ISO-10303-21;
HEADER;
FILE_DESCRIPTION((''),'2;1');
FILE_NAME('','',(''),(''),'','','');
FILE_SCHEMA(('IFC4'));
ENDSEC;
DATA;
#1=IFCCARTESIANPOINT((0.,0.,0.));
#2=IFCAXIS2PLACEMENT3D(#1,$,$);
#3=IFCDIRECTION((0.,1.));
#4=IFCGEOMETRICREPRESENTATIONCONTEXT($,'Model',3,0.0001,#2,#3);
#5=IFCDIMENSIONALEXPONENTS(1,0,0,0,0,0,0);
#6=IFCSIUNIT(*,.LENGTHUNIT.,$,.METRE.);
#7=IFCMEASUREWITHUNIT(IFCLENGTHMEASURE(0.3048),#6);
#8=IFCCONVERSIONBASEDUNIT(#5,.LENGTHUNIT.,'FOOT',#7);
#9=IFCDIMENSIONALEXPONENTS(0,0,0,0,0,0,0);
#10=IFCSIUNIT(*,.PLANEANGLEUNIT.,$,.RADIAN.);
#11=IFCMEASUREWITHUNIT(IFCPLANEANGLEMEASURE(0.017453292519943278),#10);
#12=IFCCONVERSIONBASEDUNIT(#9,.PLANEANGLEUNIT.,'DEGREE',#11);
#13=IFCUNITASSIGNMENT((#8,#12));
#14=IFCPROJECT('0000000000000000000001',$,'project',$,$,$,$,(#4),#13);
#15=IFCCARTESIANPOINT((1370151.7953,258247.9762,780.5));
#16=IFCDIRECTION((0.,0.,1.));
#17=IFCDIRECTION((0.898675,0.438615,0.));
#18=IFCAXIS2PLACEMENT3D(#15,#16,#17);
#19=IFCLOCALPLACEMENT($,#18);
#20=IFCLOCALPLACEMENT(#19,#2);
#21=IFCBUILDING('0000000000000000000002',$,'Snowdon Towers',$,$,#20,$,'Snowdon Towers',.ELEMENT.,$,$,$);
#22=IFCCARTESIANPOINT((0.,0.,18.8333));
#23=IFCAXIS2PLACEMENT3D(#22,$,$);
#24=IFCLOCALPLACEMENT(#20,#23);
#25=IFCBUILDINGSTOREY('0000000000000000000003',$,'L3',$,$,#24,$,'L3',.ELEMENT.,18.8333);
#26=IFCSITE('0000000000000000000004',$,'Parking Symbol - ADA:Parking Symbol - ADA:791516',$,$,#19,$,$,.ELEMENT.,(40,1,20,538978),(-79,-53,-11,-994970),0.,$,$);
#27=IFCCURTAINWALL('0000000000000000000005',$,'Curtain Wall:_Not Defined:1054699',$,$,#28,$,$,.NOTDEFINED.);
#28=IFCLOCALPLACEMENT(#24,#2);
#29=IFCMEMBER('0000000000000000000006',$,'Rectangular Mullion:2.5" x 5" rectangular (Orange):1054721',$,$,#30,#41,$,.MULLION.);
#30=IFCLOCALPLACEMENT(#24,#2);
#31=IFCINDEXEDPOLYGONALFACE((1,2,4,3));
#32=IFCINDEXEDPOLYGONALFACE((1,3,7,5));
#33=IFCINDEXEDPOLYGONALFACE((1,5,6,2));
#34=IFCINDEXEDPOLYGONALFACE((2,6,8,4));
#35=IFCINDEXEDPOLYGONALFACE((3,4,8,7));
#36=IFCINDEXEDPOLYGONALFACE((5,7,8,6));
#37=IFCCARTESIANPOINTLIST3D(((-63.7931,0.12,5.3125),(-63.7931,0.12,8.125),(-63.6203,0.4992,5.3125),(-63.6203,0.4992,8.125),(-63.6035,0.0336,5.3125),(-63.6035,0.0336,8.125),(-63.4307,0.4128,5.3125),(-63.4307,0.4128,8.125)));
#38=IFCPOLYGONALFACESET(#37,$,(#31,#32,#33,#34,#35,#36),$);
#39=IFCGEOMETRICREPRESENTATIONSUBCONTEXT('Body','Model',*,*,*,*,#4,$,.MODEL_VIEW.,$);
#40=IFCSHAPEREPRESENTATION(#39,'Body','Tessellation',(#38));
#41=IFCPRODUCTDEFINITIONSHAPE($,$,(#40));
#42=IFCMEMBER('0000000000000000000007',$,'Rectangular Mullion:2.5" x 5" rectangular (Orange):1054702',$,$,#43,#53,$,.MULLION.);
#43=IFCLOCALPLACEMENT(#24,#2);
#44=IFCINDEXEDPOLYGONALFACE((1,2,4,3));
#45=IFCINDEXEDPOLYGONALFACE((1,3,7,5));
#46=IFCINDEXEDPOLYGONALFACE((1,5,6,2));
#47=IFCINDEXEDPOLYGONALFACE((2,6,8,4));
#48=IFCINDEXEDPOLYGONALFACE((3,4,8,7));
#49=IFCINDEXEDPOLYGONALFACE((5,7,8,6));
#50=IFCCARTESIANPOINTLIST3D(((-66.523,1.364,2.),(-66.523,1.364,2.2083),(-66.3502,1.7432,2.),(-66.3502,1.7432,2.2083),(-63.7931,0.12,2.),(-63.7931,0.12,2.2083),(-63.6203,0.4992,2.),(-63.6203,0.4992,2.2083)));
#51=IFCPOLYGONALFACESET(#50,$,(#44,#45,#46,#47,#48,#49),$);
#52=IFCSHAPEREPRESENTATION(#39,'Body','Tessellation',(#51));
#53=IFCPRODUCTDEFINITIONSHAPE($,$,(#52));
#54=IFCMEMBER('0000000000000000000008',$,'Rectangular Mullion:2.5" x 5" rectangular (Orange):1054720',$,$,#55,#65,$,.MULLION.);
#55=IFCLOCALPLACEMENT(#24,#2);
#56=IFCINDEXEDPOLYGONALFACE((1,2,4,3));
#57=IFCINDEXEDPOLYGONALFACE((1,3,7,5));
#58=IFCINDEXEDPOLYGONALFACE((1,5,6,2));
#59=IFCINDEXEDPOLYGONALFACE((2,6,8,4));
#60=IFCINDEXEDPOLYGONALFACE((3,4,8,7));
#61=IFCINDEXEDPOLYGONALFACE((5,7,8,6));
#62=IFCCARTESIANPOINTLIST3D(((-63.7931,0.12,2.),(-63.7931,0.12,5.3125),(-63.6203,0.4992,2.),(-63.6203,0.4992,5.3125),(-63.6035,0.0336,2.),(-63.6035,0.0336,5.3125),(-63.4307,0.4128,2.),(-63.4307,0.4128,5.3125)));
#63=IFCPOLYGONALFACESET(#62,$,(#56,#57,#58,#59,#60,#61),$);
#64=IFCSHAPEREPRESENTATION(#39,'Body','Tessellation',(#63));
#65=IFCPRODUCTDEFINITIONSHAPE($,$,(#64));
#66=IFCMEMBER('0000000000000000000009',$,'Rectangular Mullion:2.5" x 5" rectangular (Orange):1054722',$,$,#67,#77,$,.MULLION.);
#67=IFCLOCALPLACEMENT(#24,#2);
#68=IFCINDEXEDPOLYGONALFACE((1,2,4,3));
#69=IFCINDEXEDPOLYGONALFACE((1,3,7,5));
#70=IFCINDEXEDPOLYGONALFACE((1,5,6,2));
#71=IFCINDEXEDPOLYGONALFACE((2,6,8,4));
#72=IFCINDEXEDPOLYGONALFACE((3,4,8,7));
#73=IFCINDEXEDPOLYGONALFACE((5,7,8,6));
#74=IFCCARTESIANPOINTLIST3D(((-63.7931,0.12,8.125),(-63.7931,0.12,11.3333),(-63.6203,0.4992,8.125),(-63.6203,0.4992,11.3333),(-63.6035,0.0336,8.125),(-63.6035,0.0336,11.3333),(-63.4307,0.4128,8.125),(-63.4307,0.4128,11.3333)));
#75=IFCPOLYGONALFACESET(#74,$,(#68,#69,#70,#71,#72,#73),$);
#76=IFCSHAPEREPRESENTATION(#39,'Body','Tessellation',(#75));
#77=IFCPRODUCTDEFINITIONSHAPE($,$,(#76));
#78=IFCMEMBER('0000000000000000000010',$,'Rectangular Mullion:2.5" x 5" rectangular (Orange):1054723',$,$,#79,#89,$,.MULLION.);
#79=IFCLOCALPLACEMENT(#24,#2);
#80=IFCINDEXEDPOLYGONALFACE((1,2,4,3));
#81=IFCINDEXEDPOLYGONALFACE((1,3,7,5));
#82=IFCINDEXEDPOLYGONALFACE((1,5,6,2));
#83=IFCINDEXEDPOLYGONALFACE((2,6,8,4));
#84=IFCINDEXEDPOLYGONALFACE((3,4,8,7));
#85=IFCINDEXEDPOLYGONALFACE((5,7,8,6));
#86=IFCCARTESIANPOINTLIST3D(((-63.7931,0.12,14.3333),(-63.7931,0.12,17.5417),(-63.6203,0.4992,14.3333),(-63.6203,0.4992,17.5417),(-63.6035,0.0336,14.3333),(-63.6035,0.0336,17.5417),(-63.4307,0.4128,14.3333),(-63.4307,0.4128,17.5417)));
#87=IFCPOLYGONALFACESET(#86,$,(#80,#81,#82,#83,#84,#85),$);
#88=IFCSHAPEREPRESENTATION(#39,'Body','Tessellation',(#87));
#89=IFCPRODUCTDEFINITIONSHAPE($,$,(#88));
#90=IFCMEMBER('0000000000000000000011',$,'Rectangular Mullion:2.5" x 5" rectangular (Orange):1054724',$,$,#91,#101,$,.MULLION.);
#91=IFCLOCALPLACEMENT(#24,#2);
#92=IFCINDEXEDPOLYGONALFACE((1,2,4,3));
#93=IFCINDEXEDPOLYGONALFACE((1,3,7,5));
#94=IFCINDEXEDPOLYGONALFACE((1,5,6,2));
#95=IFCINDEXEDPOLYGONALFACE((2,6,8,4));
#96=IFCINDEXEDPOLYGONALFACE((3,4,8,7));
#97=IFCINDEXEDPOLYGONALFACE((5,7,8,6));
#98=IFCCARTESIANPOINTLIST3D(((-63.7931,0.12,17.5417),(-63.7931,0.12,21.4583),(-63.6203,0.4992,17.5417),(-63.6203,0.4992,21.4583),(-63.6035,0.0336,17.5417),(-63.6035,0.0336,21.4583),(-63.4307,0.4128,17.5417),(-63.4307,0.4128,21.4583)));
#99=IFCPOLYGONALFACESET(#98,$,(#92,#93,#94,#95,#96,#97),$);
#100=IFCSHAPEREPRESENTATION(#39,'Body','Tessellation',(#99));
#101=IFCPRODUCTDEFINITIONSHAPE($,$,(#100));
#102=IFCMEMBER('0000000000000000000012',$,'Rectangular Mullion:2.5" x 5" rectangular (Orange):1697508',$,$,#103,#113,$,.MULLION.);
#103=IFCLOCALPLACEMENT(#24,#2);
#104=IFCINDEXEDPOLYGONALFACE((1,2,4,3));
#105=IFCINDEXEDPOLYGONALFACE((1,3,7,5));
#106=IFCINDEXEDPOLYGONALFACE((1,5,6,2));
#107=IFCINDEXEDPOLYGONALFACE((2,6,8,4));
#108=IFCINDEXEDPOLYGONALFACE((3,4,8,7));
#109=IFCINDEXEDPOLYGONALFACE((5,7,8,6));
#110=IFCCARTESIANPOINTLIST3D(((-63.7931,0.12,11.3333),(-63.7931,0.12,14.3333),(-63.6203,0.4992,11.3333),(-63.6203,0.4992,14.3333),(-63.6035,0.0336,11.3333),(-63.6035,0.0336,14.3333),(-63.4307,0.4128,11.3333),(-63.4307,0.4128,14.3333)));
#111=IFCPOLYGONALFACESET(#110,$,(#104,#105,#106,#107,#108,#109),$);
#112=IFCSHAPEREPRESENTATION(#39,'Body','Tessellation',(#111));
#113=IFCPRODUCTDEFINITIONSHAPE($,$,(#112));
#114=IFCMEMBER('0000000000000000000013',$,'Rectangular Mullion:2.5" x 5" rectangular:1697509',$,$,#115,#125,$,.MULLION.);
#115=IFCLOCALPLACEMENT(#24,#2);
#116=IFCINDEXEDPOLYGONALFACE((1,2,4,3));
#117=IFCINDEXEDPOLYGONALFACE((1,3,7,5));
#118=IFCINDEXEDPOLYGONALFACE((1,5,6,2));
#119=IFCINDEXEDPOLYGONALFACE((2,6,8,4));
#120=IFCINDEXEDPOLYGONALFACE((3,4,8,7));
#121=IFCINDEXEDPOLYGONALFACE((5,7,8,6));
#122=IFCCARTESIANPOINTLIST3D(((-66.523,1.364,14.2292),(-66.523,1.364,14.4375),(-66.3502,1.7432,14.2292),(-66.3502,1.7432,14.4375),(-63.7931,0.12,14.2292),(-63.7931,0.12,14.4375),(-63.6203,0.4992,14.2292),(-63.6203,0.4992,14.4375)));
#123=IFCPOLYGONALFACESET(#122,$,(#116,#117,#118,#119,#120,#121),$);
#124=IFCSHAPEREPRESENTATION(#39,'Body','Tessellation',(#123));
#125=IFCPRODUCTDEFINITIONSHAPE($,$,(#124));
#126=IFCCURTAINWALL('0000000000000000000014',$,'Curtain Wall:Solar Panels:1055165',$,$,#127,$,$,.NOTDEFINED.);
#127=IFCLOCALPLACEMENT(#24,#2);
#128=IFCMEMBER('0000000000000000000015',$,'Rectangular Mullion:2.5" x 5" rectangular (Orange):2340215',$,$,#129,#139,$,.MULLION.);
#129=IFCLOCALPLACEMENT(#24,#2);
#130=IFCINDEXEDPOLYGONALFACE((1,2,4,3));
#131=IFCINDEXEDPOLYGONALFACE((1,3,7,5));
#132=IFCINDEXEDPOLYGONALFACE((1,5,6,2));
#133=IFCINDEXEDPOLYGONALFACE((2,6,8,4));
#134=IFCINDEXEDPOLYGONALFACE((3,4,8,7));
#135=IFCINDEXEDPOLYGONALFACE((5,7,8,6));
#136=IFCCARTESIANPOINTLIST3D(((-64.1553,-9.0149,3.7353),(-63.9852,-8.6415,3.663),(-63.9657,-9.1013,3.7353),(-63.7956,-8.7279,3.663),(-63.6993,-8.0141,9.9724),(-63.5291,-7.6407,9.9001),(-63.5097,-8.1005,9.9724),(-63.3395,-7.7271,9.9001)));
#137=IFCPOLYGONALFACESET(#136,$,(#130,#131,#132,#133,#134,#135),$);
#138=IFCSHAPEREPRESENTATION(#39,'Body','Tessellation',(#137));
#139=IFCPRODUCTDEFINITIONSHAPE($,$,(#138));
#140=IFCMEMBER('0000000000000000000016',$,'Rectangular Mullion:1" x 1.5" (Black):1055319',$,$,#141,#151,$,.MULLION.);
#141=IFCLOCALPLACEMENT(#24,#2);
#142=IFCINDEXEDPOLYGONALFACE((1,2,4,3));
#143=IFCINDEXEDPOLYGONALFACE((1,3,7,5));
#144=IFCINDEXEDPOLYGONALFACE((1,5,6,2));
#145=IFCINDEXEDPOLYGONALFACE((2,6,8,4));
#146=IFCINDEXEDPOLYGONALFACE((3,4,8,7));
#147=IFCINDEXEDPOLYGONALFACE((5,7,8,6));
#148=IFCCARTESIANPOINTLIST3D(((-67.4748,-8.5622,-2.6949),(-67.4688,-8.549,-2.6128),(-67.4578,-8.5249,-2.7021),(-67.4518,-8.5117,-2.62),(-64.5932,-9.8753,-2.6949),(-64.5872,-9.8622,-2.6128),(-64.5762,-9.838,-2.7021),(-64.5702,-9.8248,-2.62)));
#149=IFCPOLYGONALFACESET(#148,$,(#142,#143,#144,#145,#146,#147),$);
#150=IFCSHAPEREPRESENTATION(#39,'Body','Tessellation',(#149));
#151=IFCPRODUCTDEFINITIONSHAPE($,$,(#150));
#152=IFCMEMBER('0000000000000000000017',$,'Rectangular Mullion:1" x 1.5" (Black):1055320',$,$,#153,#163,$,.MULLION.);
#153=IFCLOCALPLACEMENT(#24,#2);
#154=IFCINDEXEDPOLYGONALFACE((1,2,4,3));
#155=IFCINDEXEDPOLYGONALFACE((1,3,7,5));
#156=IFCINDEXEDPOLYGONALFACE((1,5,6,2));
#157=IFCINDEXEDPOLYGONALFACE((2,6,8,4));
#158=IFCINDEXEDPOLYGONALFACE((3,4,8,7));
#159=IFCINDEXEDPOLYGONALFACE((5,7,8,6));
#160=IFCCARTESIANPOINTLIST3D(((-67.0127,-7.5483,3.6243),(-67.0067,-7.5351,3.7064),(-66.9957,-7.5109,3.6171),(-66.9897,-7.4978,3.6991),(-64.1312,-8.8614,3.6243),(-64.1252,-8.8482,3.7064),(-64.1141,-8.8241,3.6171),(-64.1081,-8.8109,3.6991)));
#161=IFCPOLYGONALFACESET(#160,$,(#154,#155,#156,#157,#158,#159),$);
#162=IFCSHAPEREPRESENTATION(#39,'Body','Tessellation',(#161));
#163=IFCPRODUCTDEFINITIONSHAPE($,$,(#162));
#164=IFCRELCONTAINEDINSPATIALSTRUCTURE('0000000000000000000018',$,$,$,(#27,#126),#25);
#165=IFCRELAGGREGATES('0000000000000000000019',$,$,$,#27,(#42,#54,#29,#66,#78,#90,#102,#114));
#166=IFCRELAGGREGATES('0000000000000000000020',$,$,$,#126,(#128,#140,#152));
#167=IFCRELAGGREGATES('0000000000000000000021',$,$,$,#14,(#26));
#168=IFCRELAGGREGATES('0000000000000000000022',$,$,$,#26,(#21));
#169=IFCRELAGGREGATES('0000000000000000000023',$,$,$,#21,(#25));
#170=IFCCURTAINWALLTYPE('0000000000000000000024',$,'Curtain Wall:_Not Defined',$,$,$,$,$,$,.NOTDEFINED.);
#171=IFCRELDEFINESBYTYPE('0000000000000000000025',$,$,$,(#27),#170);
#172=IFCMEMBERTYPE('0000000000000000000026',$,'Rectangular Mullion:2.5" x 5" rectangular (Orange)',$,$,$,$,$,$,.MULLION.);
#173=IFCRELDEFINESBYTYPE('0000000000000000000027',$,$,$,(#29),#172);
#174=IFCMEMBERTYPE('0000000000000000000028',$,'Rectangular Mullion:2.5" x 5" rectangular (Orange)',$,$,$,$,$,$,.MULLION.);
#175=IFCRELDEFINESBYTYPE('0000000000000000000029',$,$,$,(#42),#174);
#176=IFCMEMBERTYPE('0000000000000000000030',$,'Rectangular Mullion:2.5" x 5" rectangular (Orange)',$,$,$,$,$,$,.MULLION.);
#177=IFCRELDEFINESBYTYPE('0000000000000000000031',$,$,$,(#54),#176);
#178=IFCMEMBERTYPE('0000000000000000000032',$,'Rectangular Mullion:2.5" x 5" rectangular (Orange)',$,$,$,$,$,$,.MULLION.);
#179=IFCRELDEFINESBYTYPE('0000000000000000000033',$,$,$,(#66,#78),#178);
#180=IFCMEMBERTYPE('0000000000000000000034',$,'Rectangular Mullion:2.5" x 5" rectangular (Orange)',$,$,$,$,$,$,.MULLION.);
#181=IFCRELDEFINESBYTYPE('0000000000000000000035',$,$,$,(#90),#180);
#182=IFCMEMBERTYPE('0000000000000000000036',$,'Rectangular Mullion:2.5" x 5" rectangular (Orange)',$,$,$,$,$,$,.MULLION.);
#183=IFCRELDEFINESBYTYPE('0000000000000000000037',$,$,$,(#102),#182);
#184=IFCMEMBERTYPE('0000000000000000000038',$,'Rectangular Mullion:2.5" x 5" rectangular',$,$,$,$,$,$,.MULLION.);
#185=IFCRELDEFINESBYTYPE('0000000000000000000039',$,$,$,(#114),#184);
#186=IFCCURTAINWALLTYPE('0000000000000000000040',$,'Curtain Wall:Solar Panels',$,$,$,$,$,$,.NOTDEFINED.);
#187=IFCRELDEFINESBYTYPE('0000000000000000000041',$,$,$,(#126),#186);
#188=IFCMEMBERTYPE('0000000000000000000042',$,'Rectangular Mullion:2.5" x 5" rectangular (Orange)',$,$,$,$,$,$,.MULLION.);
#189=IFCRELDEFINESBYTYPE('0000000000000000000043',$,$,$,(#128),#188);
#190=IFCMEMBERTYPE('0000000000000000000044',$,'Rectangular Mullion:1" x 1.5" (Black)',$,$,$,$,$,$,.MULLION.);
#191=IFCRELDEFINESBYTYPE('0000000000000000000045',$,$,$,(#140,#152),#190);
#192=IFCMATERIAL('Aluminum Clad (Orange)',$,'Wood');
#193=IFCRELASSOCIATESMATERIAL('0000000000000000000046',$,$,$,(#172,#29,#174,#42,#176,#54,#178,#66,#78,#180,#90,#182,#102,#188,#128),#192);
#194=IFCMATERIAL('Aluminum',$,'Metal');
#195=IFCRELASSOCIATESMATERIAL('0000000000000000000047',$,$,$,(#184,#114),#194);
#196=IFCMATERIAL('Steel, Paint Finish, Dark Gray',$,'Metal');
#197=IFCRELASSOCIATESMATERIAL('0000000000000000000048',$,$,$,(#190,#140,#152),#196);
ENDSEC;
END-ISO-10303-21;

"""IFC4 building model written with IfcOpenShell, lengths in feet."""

from ifc_helpers import new_model, entity, si_unit, converted_unit, direction, frame, origin, place, context, subcontext, project, spatial, indexed_curve, outline, extrude, source, transform, mapped, material, type_object, type_shapes, element, aggregate, save


model = new_model("IFC4")

# Units and contexts
model_context = context("Model", 3, precision=0.0001, world=origin(), true_north=direction((0.0, 1.0)))
body_context = subcontext(model_context, "Body", "Model", "MODEL_VIEW")
ifc_project = project(units=[converted_unit("LENGTHUNIT", "FOOT", entity("IfcLengthMeasure", 0.3048), si_unit("LENGTHUNIT", "METRE"), dimensions=[1, 0, 0, 0, 0, 0, 0]), converted_unit("PLANEANGLEUNIT", "DEGREE", entity("IfcPlaneAngleMeasure", 0.017453292519943278), si_unit("PLANEANGLEUNIT", "RADIAN"), dimensions=[0, 0, 0, 0, 0, 0, 0])], contexts=[model_context])

# Site, building, storey
site_placement = place(None, frame((1370151.7953, 258247.9762, 780.5), z_axis=(0.0, 0.0, 1.0), x_axis=(0.898675, 0.438615, 0.0)))
site = spatial("IfcSite", under=ifc_project, at=site_placement, Name="Parking Symbol - ADA:Parking Symbol - ADA:791516", CompositionType="ELEMENT", RefLatitude=(40, 1, 20, 538978), RefLongitude=(-79, -53, -11, -994970), RefElevation=0.0)
building_placement = place(site_placement, origin())
building = spatial("IfcBuilding", under=site, at=building_placement, Name="Snowdon Towers", LongName="Snowdon Towers", CompositionType="ELEMENT")
storey_placement = place(building_placement, frame((0.0, 0.0, 18.8333)))
storey = spatial("IfcBuildingStorey", under=building, at=storey_placement, Name="L3", LongName="L3", CompositionType="ELEMENT", Elevation=18.8333)

# Curtain walls, members
curtain_wall_type_1 = type_object("IfcCurtainWallType", Name="Curtain Wall:_Not Defined", PredefinedType="NOTDEFINED")
curtain_wall_1_placement = place(storey_placement, frame((0.0, 0.0, -18.8333)))
curtain_wall_1 = element("IfcCurtainWall", 1, at=curtain_wall_1_placement, inside=storey, type_object=curtain_wall_type_1, Name="Curtain Wall:_Not Defined:1054699", PredefinedType="NOTDEFINED")
ifc_material_1 = material(Name="Aluminum Clad (Orange)", Category="Wood")
member_type_1 = type_object("IfcMemberType", Name="Rectangular Mullion:2.5\" x 5\" rectangular (Orange)", PredefinedType="MULLION", material=ifc_material_1)
shared_shape_1 = source(origin(), body_context, "Body", "SweptSolid", [
    extrude(outline(indexed_curve([(-0.1042, -0.2083), (0.1042, -0.2083), (0.1042, 0.2083), (-0.1042, 0.2083), (-0.1042, -0.2083)], self_intersect=False)), frame((-0.1042, 0.0, -2.8125), z_axis=(0.0, 0.0, 1.0), x_axis=(-1.0, 0.0, 0.0)), (0.0, 0.0, 1.0), 2.8125),
])
type_shapes(member_type_1, [shared_shape_1])
member_1_placement = place(curtain_wall_1_placement, frame((-63.5171, 0.2232, 26.9583), z_axis=(0.0, 0.0, 1.0), x_axis=(0.909972, -0.414671, 0.0)))
member_1 = element("IfcMember", 2, at=member_1_placement, type_object=member_type_1, material=ifc_material_1, Name="Rectangular Mullion:2.5\" x 5\" rectangular (Orange):1054721", PredefinedType="MULLION", context=body_context, shape_type="MappedRepresentation", body=[
    mapped(shared_shape_1, transform((0.0, 0.0, 0.0), scale=1.0)),
])
member_type_2 = type_object("IfcMemberType", Name="Rectangular Mullion:2.5\" x 5\" rectangular (Orange)", PredefinedType="MULLION", material=ifc_material_1)
shared_shape_2 = source(origin(), body_context, "Body", "SweptSolid", [
    extrude(outline(indexed_curve([(-0.1042, -0.2083), (0.1042, -0.2083), (0.1042, 0.2083), (-0.1042, 0.2083), (-0.1042, -0.2083)], self_intersect=False)), frame((-0.1042, 0.0, -3.0), z_axis=(0.0, 0.0, 1.0), x_axis=(-1.0, 0.0, 0.0)), (0.0, 0.0, 1.0), 3.0),
])
type_shapes(member_type_2, [shared_shape_2])
member_2_placement = place(curtain_wall_1_placement, frame((-63.7067, 0.3096, 20.8333), z_axis=(0.909972, -0.414671, 0.0), x_axis=(0.0, 0.0, -1.0)))
member_2 = element("IfcMember", 3, at=member_2_placement, type_object=member_type_2, material=ifc_material_1, Name="Rectangular Mullion:2.5\" x 5\" rectangular (Orange):1054702", PredefinedType="MULLION", context=body_context, shape_type="MappedRepresentation", body=[
    mapped(shared_shape_2, transform((0.0, 0.0, 0.0), scale=1.0)),
])
member_type_3 = type_object("IfcMemberType", Name="Rectangular Mullion:2.5\" x 5\" rectangular (Orange)", PredefinedType="MULLION", material=ifc_material_1)
shared_shape_3 = source(origin(), body_context, "Body", "SweptSolid", [
    extrude(outline(indexed_curve([(-0.1042, -0.2083), (0.1042, -0.2083), (0.1042, 0.2083), (-0.1042, 0.2083), (-0.1042, -0.2083)], self_intersect=False)), frame((-0.1042, 0.0, -3.3125), z_axis=(0.0, 0.0, 1.0), x_axis=(-1.0, 0.0, 0.0)), (0.0, 0.0, 1.0), 3.3125),
])
type_shapes(member_type_3, [shared_shape_3])
member_3_placement = place(curtain_wall_1_placement, frame((-63.5171, 0.2232, 24.1458), z_axis=(0.0, 0.0, 1.0), x_axis=(0.909972, -0.414671, 0.0)))
member_3 = element("IfcMember", 4, at=member_3_placement, type_object=member_type_3, material=ifc_material_1, Name="Rectangular Mullion:2.5\" x 5\" rectangular (Orange):1054720", PredefinedType="MULLION", context=body_context, shape_type="MappedRepresentation", body=[
    mapped(shared_shape_3, transform((0.0, 0.0, 0.0), scale=1.0)),
])
member_type_4 = type_object("IfcMemberType", Name="Rectangular Mullion:2.5\" x 5\" rectangular (Orange)", PredefinedType="MULLION", material=ifc_material_1)
shared_shape_4 = source(origin(), body_context, "Body", "SweptSolid", [
    extrude(outline(indexed_curve([(-0.1042, -0.2083), (0.1042, -0.2083), (0.1042, 0.2083), (-0.1042, 0.2083), (-0.1042, -0.2083)], self_intersect=False)), frame((-0.1042, 0.0, -3.2083), z_axis=(0.0, 0.0, 1.0), x_axis=(-1.0, 0.0, 0.0)), (0.0, 0.0, 1.0), 3.2083),
])
type_shapes(member_type_4, [shared_shape_4])
member_4_placement = place(curtain_wall_1_placement, frame((-63.5171, 0.2232, 30.1667), z_axis=(0.0, 0.0, 1.0), x_axis=(0.909972, -0.414671, 0.0)))
member_4 = element("IfcMember", 5, at=member_4_placement, type_object=member_type_4, material=ifc_material_1, Name="Rectangular Mullion:2.5\" x 5\" rectangular (Orange):1054722", PredefinedType="MULLION", context=body_context, shape_type="MappedRepresentation", body=[
    mapped(shared_shape_4, transform((0.0, 0.0, 0.0), scale=1.0)),
])
member_5_placement = place(curtain_wall_1_placement, frame((-63.5171, 0.2232, 36.375), z_axis=(0.0, 0.0, 1.0), x_axis=(0.909972, -0.414671, 0.0)))
member_5 = element("IfcMember", 6, at=member_5_placement, type_object=member_type_4, material=ifc_material_1, Name="Rectangular Mullion:2.5\" x 5\" rectangular (Orange):1054723", PredefinedType="MULLION", context=body_context, shape_type="MappedRepresentation", body=[
    mapped(shared_shape_4, transform((0.0, 0.0, 0.0), scale=1.0)),
])
member_type_5 = type_object("IfcMemberType", Name="Rectangular Mullion:2.5\" x 5\" rectangular (Orange)", PredefinedType="MULLION", material=ifc_material_1)
shared_shape_5 = source(origin(), body_context, "Body", "SweptSolid", [
    extrude(outline(indexed_curve([(-0.1042, -0.2083), (0.1042, -0.2083), (0.1042, 0.2083), (-0.1042, 0.2083), (-0.1042, -0.2083)], self_intersect=False)), frame((-0.1042, 0.0, -3.9167), z_axis=(0.0, 0.0, 1.0), x_axis=(-1.0, 0.0, 0.0)), (0.0, 0.0, 1.0), 3.9167),
])
type_shapes(member_type_5, [shared_shape_5])
member_6_placement = place(curtain_wall_1_placement, frame((-63.5171, 0.2232, 40.2917), z_axis=(0.0, 0.0, 1.0), x_axis=(0.909972, -0.414671, 0.0)))
member_6 = element("IfcMember", 7, at=member_6_placement, type_object=member_type_5, material=ifc_material_1, Name="Rectangular Mullion:2.5\" x 5\" rectangular (Orange):1054724", PredefinedType="MULLION", context=body_context, shape_type="MappedRepresentation", body=[
    mapped(shared_shape_5, transform((0.0, 0.0, 0.0), scale=1.0)),
])
member_type_6 = type_object("IfcMemberType", Name="Rectangular Mullion:2.5\" x 5\" rectangular (Orange)", PredefinedType="MULLION", material=ifc_material_1)
shared_shape_6 = source(origin(), body_context, "Body", "SweptSolid", [
    extrude(outline(indexed_curve([(-0.1042, -0.2083), (0.1042, -0.2083), (0.1042, 0.2083), (-0.1042, 0.2083), (-0.1042, -0.2083)], self_intersect=False)), frame((-0.1042, 0.0, -3.0), z_axis=(0.0, 0.0, 1.0), x_axis=(-1.0, 0.0, 0.0)), (0.0, 0.0, 1.0), 3.0),
])
type_shapes(member_type_6, [shared_shape_6])
member_7_placement = place(curtain_wall_1_placement, frame((-63.5171, 0.2232, 33.1667), z_axis=(0.0, 0.0, 1.0), x_axis=(0.909972, -0.414671, 0.0)))
member_7 = element("IfcMember", 8, at=member_7_placement, type_object=member_type_6, material=ifc_material_1, Name="Rectangular Mullion:2.5\" x 5\" rectangular (Orange):1697508", PredefinedType="MULLION", context=body_context, shape_type="MappedRepresentation", body=[
    mapped(shared_shape_6, transform((0.0, 0.0, 0.0), scale=1.0)),
])
ifc_material_2 = material(Name="Aluminum", Category="Metal")
member_type_7 = type_object("IfcMemberType", Name="Rectangular Mullion:2.5\" x 5\" rectangular", PredefinedType="MULLION", material=ifc_material_2)
shared_shape_7 = source(origin(), body_context, "Body", "SweptSolid", [
    extrude(outline(indexed_curve([(-0.1042, -0.2083), (0.1042, -0.2083), (0.1042, 0.2083), (-0.1042, 0.2083), (-0.1042, -0.2083)], self_intersect=False)), frame((0.0, 0.0, -3.0), z_axis=(0.0, 0.0, 1.0), x_axis=(-1.0, 0.0, 0.0)), (0.0, 0.0, 1.0), 3.0),
])
type_shapes(member_type_7, [shared_shape_7])
member_8_placement = place(curtain_wall_1_placement, frame((-66.4366, 1.5536, 33.1667), z_axis=(-0.909972, 0.414671, 0.0), x_axis=(0.0, 0.0, 1.0)))
member_8 = element("IfcMember", 9, at=member_8_placement, type_object=member_type_7, material=ifc_material_2, Name="Rectangular Mullion:2.5\" x 5\" rectangular:1697509", PredefinedType="MULLION", context=body_context, shape_type="MappedRepresentation", body=[
    mapped(shared_shape_7, transform((0.0, 0.0, 0.0), scale=1.0)),
])
curtain_wall_type_2 = type_object("IfcCurtainWallType", Name="Curtain Wall:Solar Panels", PredefinedType="NOTDEFINED")
curtain_wall_2_placement = place(storey_placement, frame((0.0, 0.0, -18.8333)))
curtain_wall_2 = element("IfcCurtainWall", 10, at=curtain_wall_2_placement, inside=storey, type_object=curtain_wall_type_2, Name="Curtain Wall:Solar Panels:1055165", PredefinedType="NOTDEFINED")
member_type_8 = type_object("IfcMemberType", Name="Rectangular Mullion:2.5\" x 5\" rectangular (Orange)", PredefinedType="MULLION", material=ifc_material_1)
shared_shape_8 = source(origin(), body_context, "Body", "SweptSolid", [
    extrude(outline(indexed_curve([(-0.1042, -0.2083), (0.1042, -0.2083), (0.1042, 0.2083), (-0.1042, 0.2083), (-0.1042, -0.2083)], self_intersect=False)), frame((-0.1042, 0.0, -6.3333), z_axis=(0.0, 0.0, 1.0), x_axis=(-1.0, 0.0, 0.0)), (0.0, 0.0, 1.0), 6.3333),
])
type_shapes(member_type_8, [shared_shape_8])
member_9_placement = place(curtain_wall_2_placement, frame((-63.6142, -7.8274, 28.7696), z_axis=(0.072007, 0.158015, 0.984808), x_axis=(-0.909972, 0.414671, 0.0)))
member_9 = element("IfcMember", 11, at=member_9_placement, type_object=member_type_8, material=ifc_material_1, Name="Rectangular Mullion:2.5\" x 5\" rectangular (Orange):2340215", PredefinedType="MULLION", context=body_context, shape_type="MappedRepresentation", body=[
    mapped(shared_shape_8, transform((0.0, 0.0, 0.0), scale=1.0)),
])
ifc_material_3 = material(Name="Steel, Paint Finish, Dark Gray", Category="Metal")
member_type_9 = type_object("IfcMemberType", Name="Rectangular Mullion:1\" x 1.5\" (Black)", PredefinedType="MULLION", material=ifc_material_3)
shared_shape_9 = source(origin(), body_context, "Body", "SweptSolid", [
    extrude(outline(indexed_curve([(-0.0417, -0.0208), (0.0417, -0.0208), (0.0417, 0.0208), (-0.0417, 0.0208), (-0.0417, -0.0208)], self_intersect=False)), frame((0.0, 0.0208, -3.1667), z_axis=(0.0, 0.0, 1.0), x_axis=(-1.0, 0.0, 0.0)), (0.0, 0.0, 1.0), 3.1667),
])
type_shapes(member_type_9, [shared_shape_9])
member_10_placement = place(curtain_wall_2_placement, frame((-64.5732, -9.8314, 16.1723), z_axis=(0.909972, -0.414671, 0.0), x_axis=(0.072007, 0.158015, 0.984808)))
member_10 = element("IfcMember", 12, at=member_10_placement, type_object=member_type_9, material=ifc_material_3, Name="Rectangular Mullion:1\" x 1.5\" (Black):1055319", PredefinedType="MULLION", context=body_context, shape_type="MappedRepresentation", body=[
    mapped(shared_shape_9, transform((0.0, 0.0, 0.0), scale=1.0)),
])
member_11_placement = place(curtain_wall_2_placement, frame((-64.1111, -8.8175, 22.4914), z_axis=(0.909972, -0.414671, 0.0), x_axis=(0.072007, 0.158015, 0.984808)))
member_11 = element("IfcMember", 13, at=member_11_placement, type_object=member_type_9, material=ifc_material_3, Name="Rectangular Mullion:1\" x 1.5\" (Black):1055320", PredefinedType="MULLION", context=body_context, shape_type="MappedRepresentation", body=[
    mapped(shared_shape_9, transform((0.0, 0.0, 0.0), scale=1.0)),
])

aggregate(curtain_wall_1, [member_2, member_3, member_1, member_4, member_5, member_6, member_7, member_8])
aggregate(curtain_wall_2, [member_9, member_10, member_11])

save(model, "model.ifc")
